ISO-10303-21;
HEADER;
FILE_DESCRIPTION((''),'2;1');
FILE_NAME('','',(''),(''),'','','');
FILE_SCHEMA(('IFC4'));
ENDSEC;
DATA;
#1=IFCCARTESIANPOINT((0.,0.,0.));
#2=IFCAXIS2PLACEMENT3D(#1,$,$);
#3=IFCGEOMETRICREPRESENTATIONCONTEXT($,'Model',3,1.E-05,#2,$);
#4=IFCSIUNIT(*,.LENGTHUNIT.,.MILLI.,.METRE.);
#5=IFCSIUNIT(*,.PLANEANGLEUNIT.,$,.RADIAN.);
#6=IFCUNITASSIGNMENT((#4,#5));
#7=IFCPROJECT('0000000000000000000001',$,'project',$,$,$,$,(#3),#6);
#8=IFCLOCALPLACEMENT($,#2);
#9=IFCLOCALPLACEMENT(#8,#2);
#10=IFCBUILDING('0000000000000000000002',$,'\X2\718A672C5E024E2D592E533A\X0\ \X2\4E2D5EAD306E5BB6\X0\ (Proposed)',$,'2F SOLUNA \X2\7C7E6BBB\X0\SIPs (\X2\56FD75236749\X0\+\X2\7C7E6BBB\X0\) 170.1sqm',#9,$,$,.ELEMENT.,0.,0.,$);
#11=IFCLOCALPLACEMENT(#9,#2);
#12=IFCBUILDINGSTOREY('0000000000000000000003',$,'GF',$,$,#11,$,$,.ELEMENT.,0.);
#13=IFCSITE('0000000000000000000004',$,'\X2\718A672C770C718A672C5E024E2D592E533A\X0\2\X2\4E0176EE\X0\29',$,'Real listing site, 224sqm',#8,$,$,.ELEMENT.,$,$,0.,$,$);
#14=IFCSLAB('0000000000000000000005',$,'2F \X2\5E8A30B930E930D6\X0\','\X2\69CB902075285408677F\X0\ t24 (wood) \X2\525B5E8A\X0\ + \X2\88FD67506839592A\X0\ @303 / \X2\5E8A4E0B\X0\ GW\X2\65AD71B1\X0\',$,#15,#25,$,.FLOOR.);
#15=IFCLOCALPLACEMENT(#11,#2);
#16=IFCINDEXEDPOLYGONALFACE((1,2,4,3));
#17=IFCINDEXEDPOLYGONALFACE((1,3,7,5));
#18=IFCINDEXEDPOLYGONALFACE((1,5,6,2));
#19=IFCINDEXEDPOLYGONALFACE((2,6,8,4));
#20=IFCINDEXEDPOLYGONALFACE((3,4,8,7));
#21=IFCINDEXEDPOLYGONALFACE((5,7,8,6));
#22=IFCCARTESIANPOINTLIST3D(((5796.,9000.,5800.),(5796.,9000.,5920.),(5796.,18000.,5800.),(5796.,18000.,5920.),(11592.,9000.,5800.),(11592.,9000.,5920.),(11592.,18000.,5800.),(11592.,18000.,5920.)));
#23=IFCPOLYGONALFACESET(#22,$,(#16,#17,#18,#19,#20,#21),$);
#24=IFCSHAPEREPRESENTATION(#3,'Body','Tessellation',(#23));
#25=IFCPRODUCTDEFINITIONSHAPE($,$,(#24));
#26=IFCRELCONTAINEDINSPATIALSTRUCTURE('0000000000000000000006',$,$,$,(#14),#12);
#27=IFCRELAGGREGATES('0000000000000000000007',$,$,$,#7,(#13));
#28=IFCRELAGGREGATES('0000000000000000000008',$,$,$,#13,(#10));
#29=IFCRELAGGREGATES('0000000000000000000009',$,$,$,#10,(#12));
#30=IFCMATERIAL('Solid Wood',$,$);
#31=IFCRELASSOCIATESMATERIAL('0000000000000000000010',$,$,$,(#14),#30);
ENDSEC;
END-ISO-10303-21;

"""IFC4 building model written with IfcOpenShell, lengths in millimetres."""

from ifc_helpers import new_model, si_unit, frame, frame_2d, origin, place, context, project, spatial, rectangle, extrude, material, element, save


model = new_model("IFC4")

# Units and contexts
model_context = context("Model", 3, precision=1e-05, world=origin())
ifc_project = project(units=[si_unit("LENGTHUNIT", "METRE", prefix="MILLI"), si_unit("PLANEANGLEUNIT", "RADIAN")], contexts=[model_context])

# Site, building, storey
site_placement = place(None, origin())
site = spatial("IfcSite", under=ifc_project, at=site_placement, Name="熊本県熊本市中央区2丁目29", ObjectType="Real listing site, 224sqm", CompositionType="ELEMENT", RefElevation=0.0)
building_placement = place(site_placement, origin())
building = spatial("IfcBuilding", under=site, at=building_placement, Name="熊本市中央区 中庭の家 (Proposed)", ObjectType="2F SOLUNA 籾殻SIPs (国産杉+籾殻) 170.1sqm", CompositionType="ELEMENT", ElevationOfRefHeight=0.0, ElevationOfTerrain=0.0)
storey_placement = place(building_placement, origin())
storey = spatial("IfcBuildingStorey", under=building, at=storey_placement, Name="GF", CompositionType="ELEMENT", Elevation=0.0)

# Slab
ifc_material_1 = material(Name="Solid Wood")
slab_placement = place(storey_placement, frame((2898.0, 4500.0, 2900.0)))
element("IfcSlab", 1, at=slab_placement, inside=storey, material=ifc_material_1, Name="2F 床スラブ", Description="構造用合板 t24 (wood) 剛床 + 製材根太 @303 / 床下 GW断熱", PredefinedType="FLOOR", context=model_context, shape_type="SweptSolid", body=[
    extrude(rectangle(XDim=5796.0, YDim=9000.0, at=frame_2d((2898.0, 4500.0))), frame((2898.0, 4500.0, 2900.0)), (0.0, 0.0, 1.0), 120.0),
])

save(model, "model.ifc")
